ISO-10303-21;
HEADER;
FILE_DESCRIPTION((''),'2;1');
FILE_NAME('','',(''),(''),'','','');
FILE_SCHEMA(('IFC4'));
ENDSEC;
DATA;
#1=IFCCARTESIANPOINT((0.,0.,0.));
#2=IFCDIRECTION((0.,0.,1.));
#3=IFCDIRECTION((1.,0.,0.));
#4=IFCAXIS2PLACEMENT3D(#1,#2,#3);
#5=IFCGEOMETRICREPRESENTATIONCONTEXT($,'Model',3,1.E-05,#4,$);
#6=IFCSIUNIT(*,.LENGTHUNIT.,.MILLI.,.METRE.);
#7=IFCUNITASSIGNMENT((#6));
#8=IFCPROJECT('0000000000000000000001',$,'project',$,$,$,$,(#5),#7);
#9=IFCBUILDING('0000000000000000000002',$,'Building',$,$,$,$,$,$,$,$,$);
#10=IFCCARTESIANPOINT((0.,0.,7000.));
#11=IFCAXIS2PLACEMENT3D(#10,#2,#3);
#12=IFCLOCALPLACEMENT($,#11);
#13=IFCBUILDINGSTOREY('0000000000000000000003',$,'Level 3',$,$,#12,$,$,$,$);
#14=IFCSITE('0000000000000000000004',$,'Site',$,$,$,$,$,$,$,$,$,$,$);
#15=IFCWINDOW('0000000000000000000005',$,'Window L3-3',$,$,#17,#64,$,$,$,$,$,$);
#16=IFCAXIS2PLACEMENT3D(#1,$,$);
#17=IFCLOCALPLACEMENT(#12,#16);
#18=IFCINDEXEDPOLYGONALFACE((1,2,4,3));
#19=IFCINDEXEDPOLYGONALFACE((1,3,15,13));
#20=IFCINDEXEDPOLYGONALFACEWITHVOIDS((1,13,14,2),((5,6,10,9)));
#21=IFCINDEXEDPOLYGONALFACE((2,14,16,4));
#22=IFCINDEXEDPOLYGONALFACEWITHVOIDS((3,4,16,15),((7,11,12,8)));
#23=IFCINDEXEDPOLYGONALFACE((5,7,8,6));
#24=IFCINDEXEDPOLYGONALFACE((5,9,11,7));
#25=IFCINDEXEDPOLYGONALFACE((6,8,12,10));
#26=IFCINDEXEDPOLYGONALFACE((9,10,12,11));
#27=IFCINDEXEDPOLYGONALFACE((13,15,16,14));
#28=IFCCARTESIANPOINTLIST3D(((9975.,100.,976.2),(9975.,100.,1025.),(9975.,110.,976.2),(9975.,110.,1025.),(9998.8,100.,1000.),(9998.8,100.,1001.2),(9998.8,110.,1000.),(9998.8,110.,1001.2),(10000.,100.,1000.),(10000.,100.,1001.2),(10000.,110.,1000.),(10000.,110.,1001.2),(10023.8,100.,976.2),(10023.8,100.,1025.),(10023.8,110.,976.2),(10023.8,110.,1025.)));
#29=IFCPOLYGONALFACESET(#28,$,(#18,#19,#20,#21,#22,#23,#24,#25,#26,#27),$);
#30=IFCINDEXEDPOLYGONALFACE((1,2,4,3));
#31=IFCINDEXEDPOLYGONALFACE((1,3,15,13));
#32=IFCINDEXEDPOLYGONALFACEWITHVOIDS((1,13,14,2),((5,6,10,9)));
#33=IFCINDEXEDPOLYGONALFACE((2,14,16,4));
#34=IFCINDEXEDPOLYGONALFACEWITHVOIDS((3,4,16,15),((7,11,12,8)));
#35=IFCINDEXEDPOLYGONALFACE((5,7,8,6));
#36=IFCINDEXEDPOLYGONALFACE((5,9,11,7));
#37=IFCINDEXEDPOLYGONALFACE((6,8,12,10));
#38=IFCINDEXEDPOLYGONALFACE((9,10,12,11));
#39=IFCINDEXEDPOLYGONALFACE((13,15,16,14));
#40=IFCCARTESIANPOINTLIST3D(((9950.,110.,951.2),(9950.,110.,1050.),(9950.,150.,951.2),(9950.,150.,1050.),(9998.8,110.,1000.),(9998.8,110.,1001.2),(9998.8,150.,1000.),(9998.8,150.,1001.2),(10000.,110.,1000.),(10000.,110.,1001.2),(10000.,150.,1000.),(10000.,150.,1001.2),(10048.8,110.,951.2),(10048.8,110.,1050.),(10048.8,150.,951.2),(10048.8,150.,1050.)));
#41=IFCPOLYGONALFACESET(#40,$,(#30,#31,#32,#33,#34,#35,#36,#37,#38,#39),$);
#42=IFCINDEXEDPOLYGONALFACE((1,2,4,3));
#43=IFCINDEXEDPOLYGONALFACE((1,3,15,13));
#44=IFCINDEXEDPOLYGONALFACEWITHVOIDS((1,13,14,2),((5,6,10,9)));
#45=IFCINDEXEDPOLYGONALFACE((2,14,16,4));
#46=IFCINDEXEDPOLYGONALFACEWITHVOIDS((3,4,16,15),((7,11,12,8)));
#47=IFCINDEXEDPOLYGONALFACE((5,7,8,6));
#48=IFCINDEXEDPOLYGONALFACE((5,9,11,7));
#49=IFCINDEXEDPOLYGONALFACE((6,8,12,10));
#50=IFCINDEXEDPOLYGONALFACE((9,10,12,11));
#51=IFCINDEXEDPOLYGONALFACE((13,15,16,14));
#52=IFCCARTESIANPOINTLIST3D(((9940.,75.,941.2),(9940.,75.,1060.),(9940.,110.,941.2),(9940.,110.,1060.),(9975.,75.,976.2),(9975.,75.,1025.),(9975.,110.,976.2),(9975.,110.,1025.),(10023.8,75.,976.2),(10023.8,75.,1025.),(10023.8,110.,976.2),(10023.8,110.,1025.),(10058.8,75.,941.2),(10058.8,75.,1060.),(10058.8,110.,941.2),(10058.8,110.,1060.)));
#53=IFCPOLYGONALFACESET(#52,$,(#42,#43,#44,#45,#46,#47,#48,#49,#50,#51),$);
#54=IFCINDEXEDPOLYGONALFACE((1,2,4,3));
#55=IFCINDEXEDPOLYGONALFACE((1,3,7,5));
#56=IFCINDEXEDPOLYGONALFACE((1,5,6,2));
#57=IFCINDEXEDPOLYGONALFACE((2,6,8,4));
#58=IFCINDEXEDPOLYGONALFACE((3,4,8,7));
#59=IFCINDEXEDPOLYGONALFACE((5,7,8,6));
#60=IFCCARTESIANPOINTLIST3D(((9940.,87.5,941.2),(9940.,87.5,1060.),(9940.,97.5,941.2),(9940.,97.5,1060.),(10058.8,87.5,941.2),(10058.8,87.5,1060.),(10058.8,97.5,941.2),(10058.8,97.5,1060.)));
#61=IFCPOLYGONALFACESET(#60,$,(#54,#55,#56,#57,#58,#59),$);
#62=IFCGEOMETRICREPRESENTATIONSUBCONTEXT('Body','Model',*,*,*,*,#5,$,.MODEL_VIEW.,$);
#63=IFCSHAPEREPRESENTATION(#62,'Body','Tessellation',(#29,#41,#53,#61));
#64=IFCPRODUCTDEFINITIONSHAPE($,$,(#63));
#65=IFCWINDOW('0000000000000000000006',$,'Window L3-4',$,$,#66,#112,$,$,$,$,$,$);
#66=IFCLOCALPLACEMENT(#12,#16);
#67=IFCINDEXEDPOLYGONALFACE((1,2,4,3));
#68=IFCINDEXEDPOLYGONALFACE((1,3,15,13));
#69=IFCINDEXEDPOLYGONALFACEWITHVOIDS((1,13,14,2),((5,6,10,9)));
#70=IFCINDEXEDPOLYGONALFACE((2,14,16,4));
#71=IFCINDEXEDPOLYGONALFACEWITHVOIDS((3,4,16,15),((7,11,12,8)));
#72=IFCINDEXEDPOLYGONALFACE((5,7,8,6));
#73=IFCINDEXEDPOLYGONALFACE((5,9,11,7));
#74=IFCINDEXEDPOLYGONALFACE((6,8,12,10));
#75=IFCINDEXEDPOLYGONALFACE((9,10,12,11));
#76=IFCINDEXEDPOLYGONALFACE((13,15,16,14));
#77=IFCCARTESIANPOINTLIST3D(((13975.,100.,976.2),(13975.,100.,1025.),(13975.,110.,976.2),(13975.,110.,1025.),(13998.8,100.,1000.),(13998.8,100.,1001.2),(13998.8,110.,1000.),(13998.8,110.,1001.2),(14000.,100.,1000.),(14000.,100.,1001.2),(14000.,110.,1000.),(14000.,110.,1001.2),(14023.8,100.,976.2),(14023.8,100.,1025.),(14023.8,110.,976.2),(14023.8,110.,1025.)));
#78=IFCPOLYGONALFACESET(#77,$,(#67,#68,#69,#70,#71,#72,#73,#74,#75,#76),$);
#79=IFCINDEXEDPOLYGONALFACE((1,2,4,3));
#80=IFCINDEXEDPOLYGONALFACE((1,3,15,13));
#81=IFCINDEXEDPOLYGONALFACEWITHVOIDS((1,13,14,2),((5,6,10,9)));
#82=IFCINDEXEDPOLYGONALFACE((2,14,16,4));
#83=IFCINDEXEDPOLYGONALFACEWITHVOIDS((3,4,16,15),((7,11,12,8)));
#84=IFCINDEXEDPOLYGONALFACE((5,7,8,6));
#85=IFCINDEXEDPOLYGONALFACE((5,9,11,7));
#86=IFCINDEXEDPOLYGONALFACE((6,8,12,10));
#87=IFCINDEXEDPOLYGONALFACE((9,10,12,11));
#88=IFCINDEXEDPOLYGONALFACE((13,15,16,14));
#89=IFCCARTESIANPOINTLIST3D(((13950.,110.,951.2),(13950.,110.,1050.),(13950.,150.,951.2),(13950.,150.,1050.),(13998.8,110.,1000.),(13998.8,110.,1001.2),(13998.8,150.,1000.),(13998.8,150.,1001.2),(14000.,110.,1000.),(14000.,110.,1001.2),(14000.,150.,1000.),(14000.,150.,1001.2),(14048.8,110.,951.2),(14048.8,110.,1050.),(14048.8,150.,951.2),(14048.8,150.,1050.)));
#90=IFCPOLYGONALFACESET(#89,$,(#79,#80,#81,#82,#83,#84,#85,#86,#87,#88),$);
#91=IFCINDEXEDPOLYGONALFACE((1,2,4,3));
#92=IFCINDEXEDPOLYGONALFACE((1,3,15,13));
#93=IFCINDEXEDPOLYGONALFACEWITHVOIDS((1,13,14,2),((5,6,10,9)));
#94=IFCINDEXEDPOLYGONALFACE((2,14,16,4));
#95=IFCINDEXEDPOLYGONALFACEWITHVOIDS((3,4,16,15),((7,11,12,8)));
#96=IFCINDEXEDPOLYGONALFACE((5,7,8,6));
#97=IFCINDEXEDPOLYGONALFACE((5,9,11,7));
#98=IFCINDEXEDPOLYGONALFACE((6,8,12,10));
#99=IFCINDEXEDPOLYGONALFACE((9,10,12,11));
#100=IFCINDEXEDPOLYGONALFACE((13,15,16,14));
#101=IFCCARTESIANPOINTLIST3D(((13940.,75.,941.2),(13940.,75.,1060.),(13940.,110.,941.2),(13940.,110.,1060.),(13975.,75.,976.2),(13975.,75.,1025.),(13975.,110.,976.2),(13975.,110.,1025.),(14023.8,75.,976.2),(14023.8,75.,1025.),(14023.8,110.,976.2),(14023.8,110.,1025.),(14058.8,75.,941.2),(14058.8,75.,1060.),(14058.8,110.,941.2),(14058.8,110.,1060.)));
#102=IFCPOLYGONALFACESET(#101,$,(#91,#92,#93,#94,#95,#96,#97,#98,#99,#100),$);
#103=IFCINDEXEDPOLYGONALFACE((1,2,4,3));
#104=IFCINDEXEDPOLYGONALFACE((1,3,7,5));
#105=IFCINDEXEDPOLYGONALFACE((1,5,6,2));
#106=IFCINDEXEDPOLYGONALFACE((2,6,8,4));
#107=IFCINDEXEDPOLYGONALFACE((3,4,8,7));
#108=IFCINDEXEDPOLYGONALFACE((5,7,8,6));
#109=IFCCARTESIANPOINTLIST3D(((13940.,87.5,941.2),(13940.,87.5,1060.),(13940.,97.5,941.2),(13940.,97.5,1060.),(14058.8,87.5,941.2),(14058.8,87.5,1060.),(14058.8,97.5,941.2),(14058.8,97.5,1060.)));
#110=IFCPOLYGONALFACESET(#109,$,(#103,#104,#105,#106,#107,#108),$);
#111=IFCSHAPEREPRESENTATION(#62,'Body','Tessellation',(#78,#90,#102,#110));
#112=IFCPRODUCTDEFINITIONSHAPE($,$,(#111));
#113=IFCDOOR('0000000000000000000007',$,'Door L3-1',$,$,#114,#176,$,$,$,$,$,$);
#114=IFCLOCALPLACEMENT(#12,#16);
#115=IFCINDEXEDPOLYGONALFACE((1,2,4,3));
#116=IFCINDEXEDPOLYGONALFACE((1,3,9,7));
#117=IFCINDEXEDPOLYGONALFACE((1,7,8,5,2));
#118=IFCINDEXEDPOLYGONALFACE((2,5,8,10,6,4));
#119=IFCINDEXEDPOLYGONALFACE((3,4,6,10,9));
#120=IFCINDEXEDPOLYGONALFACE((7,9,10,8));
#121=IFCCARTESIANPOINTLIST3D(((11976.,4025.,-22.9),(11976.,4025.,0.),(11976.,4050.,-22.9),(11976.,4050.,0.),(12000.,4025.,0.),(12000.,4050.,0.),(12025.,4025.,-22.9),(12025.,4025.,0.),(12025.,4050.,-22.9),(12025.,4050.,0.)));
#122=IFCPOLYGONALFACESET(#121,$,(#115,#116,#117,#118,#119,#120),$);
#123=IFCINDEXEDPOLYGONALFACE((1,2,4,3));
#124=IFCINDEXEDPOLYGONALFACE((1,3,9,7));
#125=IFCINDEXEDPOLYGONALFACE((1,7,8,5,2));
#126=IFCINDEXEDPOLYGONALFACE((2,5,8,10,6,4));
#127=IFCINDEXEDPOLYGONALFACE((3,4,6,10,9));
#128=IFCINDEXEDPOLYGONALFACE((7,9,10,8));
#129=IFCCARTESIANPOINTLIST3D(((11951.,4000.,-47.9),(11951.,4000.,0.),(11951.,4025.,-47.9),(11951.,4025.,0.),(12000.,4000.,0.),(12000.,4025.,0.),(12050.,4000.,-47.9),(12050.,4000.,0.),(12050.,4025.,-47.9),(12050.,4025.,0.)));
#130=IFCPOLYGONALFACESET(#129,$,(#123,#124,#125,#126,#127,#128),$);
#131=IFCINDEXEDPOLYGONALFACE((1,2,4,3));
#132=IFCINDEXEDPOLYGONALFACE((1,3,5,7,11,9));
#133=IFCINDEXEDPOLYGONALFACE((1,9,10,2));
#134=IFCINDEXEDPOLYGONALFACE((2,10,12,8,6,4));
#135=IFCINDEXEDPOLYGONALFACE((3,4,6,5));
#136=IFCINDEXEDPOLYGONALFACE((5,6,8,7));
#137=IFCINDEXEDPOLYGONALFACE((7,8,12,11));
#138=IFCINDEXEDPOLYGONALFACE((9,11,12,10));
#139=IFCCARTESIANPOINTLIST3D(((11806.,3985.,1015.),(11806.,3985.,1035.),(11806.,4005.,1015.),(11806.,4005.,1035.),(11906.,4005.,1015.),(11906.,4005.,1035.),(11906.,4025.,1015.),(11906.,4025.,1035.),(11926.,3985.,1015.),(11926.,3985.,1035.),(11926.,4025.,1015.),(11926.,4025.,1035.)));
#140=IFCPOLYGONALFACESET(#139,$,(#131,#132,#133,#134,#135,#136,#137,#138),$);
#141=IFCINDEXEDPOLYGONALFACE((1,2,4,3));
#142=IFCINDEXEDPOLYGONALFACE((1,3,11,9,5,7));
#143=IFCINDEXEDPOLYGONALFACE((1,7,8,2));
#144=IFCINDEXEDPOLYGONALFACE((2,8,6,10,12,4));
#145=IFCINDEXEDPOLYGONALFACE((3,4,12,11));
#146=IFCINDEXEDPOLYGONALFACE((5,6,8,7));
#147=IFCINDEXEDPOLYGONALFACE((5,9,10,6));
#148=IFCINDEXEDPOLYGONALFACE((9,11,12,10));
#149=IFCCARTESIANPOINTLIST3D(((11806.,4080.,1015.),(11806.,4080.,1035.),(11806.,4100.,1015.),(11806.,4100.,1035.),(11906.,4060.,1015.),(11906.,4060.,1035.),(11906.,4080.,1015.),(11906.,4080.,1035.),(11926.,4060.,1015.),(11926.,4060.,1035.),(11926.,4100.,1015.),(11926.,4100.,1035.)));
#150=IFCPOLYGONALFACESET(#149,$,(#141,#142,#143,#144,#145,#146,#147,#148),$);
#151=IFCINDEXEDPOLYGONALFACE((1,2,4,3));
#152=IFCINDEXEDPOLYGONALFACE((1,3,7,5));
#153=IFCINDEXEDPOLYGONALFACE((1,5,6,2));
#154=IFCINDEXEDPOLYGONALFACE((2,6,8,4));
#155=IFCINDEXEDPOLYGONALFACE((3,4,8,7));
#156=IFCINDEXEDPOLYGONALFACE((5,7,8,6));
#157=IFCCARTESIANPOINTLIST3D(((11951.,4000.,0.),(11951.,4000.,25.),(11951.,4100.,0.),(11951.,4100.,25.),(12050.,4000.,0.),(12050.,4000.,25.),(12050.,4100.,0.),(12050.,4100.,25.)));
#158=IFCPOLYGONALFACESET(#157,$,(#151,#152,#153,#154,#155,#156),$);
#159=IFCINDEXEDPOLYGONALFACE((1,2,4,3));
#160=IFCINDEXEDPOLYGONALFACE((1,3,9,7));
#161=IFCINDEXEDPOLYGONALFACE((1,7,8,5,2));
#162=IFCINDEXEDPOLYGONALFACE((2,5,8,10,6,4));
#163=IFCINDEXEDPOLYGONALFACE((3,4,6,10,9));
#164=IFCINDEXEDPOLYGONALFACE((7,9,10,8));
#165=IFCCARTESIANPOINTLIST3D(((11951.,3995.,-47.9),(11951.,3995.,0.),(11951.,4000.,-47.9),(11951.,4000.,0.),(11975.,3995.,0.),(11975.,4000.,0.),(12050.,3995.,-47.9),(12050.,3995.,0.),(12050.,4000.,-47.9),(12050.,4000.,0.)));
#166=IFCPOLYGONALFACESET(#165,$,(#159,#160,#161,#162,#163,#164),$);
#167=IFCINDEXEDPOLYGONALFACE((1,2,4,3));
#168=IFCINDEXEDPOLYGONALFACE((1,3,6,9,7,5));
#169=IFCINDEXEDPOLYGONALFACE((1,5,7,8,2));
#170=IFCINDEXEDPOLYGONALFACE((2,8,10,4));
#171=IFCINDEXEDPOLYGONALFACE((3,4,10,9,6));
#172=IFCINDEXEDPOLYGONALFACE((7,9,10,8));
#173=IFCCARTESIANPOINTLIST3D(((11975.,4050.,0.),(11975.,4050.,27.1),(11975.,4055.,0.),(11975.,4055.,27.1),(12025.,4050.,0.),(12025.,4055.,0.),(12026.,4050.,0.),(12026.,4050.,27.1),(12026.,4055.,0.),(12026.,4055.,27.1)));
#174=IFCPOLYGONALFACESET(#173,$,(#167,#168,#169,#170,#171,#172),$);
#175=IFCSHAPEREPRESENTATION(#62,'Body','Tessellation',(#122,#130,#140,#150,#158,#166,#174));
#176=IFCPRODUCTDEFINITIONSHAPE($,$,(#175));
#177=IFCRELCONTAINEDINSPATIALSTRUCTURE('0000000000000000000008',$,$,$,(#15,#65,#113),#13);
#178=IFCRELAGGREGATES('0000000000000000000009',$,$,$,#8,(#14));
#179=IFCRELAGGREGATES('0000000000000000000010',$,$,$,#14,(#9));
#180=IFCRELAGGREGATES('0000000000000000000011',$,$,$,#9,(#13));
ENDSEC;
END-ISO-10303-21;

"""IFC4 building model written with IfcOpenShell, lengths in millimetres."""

from ifc_helpers import new_model, si_unit, frame, origin_with_axes, place, context, subcontext, project, spatial, line, indexed_curve, outline, extrude, element, save


model = new_model("IFC4")

# Units and contexts
model_context = context("Model", 3, precision=1e-05, world=origin_with_axes())
body_context = subcontext(model_context, "Body", "Model", "MODEL_VIEW")
ifc_project = project(units=[si_unit("LENGTHUNIT", "METRE", prefix="MILLI")], contexts=[model_context])

# Site, building, storey
site = spatial("IfcSite", under=ifc_project, Name="Site")
building = spatial("IfcBuilding", under=site, Name="Building")
storey_placement = place(None, frame((0.0, 0.0, 7000.0), z_axis=(0.0, 0.0, 1.0), x_axis=(1.0, 0.0, 0.0)))
storey = spatial("IfcBuildingStorey", under=building, at=storey_placement, Name="Level 3")

# Windows
for number, where, z_axis, x_axis, name in (
    (1, (10000.0, 200.0, 1000.0), (0.0, 0.0, 1.0), (-1.0, 0.0, 0.0), "Window L3-3"),
    (2, (14000.0, 200.0, 1000.0), (0.0, 0.0, 1.0), (-1.0, 0.0, 0.0), "Window L3-4"),
):
    element("IfcWindow", number, at=place(storey_placement, frame(where, z_axis=z_axis, x_axis=x_axis)), inside=storey, Name=name, context=body_context, shape_type="SweptSolid", body=[
        extrude(outline(indexed_curve([(0.0, 0.0), (1.2, 0.0), (1.2, 1.2), (0.0, 1.2)], segments=[line(1, 2, 3, 4, 1)]), holes=[indexed_curve([(25.0, 25.0), (-23.8, 25.0), (-23.8, -23.8), (25.0, -23.8)], segments=[line(1, 2, 3, 4, 1)])]), frame((0.0, 90.0, 0.0), z_axis=(0.0, -1.0, 0.0), x_axis=(1.0, 0.0, 0.0)), (0.0, 0.0, -1.0), 10.0),
        extrude(outline(indexed_curve([(0.0, 0.0), (1.2, 0.0), (1.2, 1.2), (0.0, 1.2)], segments=[line(1, 2, 3, 4, 1)]), holes=[indexed_curve([(50.0, 50.0), (-48.8, 50.0), (-48.8, -48.8), (50.0, -48.8)], segments=[line(1, 2, 3, 4, 1)])]), frame((0.0, 50.0, 0.0), z_axis=(0.0, -1.0, 0.0), x_axis=(1.0, 0.0, 0.0)), (0.0, 0.0, -1.0), 40.0),
        extrude(outline(indexed_curve([(0.0, 0.0), (-48.8, 0.0), (-48.8, -48.8), (0.0, -48.8)], segments=[line(1, 2, 3, 4, 1)]), holes=[indexed_curve([(35.0, 35.0), (-83.8, 35.0), (-83.8, -83.8), (35.0, -83.8)], segments=[line(1, 2, 3, 4, 1)])]), frame((25.0, 90.0, 25.0), z_axis=(0.0, -1.0, 0.0), x_axis=(1.0, 0.0, 0.0)), (0.0, 0.0, -1.0), 35.0),
        extrude(outline(indexed_curve([(35.0, 35.0), (-83.8, 35.0), (-83.8, -83.8), (35.0, -83.8)], segments=[line(1, 2, 3, 4, 1)])), frame((25.0, 102.5, 25.0), z_axis=(0.0, -1.0, 0.0), x_axis=(1.0, 0.0, 0.0)), (0.0, 0.0, -1.0), 10.0),
    ])

# Door
door_1_placement = place(storey_placement, frame((12000.0, 4000.0, 0.0), z_axis=(0.0, 0.0, 1.0), x_axis=(1.0, 0.0, 0.0)))
element("IfcDoor", 3, at=door_1_placement, inside=storey, Name="Door L3-1", context=body_context, shape_type="SweptSolid", body=[
    extrude(outline(indexed_curve([(0.0, 0.0), (0.0, 2.1), (1.0, 2.1), (1.0, 0.0), (-24.0, 0.0), (-24.0, -22.9), (25.0, -22.9), (25.0, 0.0)], segments=[line(1, 2, 3, 4, 5, 6, 7, 8, 1)])), frame((0.0, 25.0, 0.0), z_axis=(0.0, -1.0, 0.0), x_axis=(1.0, 0.0, 0.0)), (0.0, 0.0, -1.0), 25.0),
    extrude(outline(indexed_curve([(0.0, 0.0), (0.0, 2.1), (1.0, 2.1), (1.0, 0.0), (-49.0, 0.0), (-49.0, -47.9), (50.0, -47.9), (50.0, 0.0)], segments=[line(1, 2, 3, 4, 5, 6, 7, 8, 1)])), frame((0.0, 0.0, 0.0), z_axis=(0.0, -1.0, 0.0), x_axis=(1.0, 0.0, 0.0)), (0.0, 0.0, -1.0), 25.0),
    extrude(outline(indexed_curve([(0.0, 0.0), (-49.0, 0.0), (-49.0, 35.0), (0.0, 35.0)], segments=[line(1, 2, 3, 4, 1)])), frame((25.0, 25.0, 25.0), z_axis=(0.0, 0.0, 1.0), x_axis=(1.0, 0.0, 0.0)), (0.0, 0.0, 1.0), -47.9),
    extrude(outline(indexed_curve([(0.0, 0.0), (0.0, -40.0), (-120.0, -40.0), (-120.0, -20.0), (-20.0, -20.0), (-20.0, 0.0)], segments=[line(1, 2, 3, 4, 5, 6, 1)])), frame((-74.0, 25.0, 1015.0), z_axis=(0.0, 0.0, 1.0), x_axis=(1.0, 0.0, 0.0)), (0.0, 0.0, 1.0), 20.0),
    extrude(outline(indexed_curve([(0.0, 0.0), (0.0, 40.0), (-120.0, 40.0), (-120.0, 20.0), (-20.0, 20.0), (-20.0, 0.0)], segments=[line(1, 2, 3, 4, 5, 6, 1)])), frame((-74.0, 60.0, 1015.0), z_axis=(0.0, 0.0, 1.0), x_axis=(1.0, 0.0, 0.0)), (0.0, 0.0, 1.0), 20.0),
    extrude(outline(indexed_curve([(0.0, 0.0), (-99.0, 0.0), (-99.0, 100.0), (0.0, 100.0)], segments=[line(1, 2, 3, 4, 1)])), frame((50.0, 0.0, 0.0), z_axis=(0.0, 0.0, 1.0), x_axis=(1.0, 0.0, 0.0)), (0.0, 0.0, 1.0), 25.0),
    extrude(outline(indexed_curve([(0.0, 0.0), (0.0, 27.1), (51.0, 27.1), (51.0, 0.0), (-24.0, 0.0), (-24.0, -47.9), (75.0, -47.9), (75.0, 0.0)], segments=[line(1, 2, 3, 4, 5, 6, 7, 8, 1)])), frame((-25.0, -5.0, 0.0), z_axis=(0.0, -1.0, 0.0), x_axis=(1.0, 0.0, 0.0)), (0.0, 0.0, -1.0), 5.0),
    extrude(outline(indexed_curve([(0.0, 0.0), (0.0, 27.1), (51.0, 27.1), (51.0, 0.0), (1.0, 0.0), (1.0, -22.9), (50.0, -22.9), (50.0, 0.0)], segments=[line(1, 2, 3, 4, 5, 6, 7, 8, 1)])), frame((-25.0, 50.0, 0.0), z_axis=(0.0, -1.0, 0.0), x_axis=(1.0, 0.0, 0.0)), (0.0, 0.0, -1.0), 5.0),
])

save(model, "model.ifc")
